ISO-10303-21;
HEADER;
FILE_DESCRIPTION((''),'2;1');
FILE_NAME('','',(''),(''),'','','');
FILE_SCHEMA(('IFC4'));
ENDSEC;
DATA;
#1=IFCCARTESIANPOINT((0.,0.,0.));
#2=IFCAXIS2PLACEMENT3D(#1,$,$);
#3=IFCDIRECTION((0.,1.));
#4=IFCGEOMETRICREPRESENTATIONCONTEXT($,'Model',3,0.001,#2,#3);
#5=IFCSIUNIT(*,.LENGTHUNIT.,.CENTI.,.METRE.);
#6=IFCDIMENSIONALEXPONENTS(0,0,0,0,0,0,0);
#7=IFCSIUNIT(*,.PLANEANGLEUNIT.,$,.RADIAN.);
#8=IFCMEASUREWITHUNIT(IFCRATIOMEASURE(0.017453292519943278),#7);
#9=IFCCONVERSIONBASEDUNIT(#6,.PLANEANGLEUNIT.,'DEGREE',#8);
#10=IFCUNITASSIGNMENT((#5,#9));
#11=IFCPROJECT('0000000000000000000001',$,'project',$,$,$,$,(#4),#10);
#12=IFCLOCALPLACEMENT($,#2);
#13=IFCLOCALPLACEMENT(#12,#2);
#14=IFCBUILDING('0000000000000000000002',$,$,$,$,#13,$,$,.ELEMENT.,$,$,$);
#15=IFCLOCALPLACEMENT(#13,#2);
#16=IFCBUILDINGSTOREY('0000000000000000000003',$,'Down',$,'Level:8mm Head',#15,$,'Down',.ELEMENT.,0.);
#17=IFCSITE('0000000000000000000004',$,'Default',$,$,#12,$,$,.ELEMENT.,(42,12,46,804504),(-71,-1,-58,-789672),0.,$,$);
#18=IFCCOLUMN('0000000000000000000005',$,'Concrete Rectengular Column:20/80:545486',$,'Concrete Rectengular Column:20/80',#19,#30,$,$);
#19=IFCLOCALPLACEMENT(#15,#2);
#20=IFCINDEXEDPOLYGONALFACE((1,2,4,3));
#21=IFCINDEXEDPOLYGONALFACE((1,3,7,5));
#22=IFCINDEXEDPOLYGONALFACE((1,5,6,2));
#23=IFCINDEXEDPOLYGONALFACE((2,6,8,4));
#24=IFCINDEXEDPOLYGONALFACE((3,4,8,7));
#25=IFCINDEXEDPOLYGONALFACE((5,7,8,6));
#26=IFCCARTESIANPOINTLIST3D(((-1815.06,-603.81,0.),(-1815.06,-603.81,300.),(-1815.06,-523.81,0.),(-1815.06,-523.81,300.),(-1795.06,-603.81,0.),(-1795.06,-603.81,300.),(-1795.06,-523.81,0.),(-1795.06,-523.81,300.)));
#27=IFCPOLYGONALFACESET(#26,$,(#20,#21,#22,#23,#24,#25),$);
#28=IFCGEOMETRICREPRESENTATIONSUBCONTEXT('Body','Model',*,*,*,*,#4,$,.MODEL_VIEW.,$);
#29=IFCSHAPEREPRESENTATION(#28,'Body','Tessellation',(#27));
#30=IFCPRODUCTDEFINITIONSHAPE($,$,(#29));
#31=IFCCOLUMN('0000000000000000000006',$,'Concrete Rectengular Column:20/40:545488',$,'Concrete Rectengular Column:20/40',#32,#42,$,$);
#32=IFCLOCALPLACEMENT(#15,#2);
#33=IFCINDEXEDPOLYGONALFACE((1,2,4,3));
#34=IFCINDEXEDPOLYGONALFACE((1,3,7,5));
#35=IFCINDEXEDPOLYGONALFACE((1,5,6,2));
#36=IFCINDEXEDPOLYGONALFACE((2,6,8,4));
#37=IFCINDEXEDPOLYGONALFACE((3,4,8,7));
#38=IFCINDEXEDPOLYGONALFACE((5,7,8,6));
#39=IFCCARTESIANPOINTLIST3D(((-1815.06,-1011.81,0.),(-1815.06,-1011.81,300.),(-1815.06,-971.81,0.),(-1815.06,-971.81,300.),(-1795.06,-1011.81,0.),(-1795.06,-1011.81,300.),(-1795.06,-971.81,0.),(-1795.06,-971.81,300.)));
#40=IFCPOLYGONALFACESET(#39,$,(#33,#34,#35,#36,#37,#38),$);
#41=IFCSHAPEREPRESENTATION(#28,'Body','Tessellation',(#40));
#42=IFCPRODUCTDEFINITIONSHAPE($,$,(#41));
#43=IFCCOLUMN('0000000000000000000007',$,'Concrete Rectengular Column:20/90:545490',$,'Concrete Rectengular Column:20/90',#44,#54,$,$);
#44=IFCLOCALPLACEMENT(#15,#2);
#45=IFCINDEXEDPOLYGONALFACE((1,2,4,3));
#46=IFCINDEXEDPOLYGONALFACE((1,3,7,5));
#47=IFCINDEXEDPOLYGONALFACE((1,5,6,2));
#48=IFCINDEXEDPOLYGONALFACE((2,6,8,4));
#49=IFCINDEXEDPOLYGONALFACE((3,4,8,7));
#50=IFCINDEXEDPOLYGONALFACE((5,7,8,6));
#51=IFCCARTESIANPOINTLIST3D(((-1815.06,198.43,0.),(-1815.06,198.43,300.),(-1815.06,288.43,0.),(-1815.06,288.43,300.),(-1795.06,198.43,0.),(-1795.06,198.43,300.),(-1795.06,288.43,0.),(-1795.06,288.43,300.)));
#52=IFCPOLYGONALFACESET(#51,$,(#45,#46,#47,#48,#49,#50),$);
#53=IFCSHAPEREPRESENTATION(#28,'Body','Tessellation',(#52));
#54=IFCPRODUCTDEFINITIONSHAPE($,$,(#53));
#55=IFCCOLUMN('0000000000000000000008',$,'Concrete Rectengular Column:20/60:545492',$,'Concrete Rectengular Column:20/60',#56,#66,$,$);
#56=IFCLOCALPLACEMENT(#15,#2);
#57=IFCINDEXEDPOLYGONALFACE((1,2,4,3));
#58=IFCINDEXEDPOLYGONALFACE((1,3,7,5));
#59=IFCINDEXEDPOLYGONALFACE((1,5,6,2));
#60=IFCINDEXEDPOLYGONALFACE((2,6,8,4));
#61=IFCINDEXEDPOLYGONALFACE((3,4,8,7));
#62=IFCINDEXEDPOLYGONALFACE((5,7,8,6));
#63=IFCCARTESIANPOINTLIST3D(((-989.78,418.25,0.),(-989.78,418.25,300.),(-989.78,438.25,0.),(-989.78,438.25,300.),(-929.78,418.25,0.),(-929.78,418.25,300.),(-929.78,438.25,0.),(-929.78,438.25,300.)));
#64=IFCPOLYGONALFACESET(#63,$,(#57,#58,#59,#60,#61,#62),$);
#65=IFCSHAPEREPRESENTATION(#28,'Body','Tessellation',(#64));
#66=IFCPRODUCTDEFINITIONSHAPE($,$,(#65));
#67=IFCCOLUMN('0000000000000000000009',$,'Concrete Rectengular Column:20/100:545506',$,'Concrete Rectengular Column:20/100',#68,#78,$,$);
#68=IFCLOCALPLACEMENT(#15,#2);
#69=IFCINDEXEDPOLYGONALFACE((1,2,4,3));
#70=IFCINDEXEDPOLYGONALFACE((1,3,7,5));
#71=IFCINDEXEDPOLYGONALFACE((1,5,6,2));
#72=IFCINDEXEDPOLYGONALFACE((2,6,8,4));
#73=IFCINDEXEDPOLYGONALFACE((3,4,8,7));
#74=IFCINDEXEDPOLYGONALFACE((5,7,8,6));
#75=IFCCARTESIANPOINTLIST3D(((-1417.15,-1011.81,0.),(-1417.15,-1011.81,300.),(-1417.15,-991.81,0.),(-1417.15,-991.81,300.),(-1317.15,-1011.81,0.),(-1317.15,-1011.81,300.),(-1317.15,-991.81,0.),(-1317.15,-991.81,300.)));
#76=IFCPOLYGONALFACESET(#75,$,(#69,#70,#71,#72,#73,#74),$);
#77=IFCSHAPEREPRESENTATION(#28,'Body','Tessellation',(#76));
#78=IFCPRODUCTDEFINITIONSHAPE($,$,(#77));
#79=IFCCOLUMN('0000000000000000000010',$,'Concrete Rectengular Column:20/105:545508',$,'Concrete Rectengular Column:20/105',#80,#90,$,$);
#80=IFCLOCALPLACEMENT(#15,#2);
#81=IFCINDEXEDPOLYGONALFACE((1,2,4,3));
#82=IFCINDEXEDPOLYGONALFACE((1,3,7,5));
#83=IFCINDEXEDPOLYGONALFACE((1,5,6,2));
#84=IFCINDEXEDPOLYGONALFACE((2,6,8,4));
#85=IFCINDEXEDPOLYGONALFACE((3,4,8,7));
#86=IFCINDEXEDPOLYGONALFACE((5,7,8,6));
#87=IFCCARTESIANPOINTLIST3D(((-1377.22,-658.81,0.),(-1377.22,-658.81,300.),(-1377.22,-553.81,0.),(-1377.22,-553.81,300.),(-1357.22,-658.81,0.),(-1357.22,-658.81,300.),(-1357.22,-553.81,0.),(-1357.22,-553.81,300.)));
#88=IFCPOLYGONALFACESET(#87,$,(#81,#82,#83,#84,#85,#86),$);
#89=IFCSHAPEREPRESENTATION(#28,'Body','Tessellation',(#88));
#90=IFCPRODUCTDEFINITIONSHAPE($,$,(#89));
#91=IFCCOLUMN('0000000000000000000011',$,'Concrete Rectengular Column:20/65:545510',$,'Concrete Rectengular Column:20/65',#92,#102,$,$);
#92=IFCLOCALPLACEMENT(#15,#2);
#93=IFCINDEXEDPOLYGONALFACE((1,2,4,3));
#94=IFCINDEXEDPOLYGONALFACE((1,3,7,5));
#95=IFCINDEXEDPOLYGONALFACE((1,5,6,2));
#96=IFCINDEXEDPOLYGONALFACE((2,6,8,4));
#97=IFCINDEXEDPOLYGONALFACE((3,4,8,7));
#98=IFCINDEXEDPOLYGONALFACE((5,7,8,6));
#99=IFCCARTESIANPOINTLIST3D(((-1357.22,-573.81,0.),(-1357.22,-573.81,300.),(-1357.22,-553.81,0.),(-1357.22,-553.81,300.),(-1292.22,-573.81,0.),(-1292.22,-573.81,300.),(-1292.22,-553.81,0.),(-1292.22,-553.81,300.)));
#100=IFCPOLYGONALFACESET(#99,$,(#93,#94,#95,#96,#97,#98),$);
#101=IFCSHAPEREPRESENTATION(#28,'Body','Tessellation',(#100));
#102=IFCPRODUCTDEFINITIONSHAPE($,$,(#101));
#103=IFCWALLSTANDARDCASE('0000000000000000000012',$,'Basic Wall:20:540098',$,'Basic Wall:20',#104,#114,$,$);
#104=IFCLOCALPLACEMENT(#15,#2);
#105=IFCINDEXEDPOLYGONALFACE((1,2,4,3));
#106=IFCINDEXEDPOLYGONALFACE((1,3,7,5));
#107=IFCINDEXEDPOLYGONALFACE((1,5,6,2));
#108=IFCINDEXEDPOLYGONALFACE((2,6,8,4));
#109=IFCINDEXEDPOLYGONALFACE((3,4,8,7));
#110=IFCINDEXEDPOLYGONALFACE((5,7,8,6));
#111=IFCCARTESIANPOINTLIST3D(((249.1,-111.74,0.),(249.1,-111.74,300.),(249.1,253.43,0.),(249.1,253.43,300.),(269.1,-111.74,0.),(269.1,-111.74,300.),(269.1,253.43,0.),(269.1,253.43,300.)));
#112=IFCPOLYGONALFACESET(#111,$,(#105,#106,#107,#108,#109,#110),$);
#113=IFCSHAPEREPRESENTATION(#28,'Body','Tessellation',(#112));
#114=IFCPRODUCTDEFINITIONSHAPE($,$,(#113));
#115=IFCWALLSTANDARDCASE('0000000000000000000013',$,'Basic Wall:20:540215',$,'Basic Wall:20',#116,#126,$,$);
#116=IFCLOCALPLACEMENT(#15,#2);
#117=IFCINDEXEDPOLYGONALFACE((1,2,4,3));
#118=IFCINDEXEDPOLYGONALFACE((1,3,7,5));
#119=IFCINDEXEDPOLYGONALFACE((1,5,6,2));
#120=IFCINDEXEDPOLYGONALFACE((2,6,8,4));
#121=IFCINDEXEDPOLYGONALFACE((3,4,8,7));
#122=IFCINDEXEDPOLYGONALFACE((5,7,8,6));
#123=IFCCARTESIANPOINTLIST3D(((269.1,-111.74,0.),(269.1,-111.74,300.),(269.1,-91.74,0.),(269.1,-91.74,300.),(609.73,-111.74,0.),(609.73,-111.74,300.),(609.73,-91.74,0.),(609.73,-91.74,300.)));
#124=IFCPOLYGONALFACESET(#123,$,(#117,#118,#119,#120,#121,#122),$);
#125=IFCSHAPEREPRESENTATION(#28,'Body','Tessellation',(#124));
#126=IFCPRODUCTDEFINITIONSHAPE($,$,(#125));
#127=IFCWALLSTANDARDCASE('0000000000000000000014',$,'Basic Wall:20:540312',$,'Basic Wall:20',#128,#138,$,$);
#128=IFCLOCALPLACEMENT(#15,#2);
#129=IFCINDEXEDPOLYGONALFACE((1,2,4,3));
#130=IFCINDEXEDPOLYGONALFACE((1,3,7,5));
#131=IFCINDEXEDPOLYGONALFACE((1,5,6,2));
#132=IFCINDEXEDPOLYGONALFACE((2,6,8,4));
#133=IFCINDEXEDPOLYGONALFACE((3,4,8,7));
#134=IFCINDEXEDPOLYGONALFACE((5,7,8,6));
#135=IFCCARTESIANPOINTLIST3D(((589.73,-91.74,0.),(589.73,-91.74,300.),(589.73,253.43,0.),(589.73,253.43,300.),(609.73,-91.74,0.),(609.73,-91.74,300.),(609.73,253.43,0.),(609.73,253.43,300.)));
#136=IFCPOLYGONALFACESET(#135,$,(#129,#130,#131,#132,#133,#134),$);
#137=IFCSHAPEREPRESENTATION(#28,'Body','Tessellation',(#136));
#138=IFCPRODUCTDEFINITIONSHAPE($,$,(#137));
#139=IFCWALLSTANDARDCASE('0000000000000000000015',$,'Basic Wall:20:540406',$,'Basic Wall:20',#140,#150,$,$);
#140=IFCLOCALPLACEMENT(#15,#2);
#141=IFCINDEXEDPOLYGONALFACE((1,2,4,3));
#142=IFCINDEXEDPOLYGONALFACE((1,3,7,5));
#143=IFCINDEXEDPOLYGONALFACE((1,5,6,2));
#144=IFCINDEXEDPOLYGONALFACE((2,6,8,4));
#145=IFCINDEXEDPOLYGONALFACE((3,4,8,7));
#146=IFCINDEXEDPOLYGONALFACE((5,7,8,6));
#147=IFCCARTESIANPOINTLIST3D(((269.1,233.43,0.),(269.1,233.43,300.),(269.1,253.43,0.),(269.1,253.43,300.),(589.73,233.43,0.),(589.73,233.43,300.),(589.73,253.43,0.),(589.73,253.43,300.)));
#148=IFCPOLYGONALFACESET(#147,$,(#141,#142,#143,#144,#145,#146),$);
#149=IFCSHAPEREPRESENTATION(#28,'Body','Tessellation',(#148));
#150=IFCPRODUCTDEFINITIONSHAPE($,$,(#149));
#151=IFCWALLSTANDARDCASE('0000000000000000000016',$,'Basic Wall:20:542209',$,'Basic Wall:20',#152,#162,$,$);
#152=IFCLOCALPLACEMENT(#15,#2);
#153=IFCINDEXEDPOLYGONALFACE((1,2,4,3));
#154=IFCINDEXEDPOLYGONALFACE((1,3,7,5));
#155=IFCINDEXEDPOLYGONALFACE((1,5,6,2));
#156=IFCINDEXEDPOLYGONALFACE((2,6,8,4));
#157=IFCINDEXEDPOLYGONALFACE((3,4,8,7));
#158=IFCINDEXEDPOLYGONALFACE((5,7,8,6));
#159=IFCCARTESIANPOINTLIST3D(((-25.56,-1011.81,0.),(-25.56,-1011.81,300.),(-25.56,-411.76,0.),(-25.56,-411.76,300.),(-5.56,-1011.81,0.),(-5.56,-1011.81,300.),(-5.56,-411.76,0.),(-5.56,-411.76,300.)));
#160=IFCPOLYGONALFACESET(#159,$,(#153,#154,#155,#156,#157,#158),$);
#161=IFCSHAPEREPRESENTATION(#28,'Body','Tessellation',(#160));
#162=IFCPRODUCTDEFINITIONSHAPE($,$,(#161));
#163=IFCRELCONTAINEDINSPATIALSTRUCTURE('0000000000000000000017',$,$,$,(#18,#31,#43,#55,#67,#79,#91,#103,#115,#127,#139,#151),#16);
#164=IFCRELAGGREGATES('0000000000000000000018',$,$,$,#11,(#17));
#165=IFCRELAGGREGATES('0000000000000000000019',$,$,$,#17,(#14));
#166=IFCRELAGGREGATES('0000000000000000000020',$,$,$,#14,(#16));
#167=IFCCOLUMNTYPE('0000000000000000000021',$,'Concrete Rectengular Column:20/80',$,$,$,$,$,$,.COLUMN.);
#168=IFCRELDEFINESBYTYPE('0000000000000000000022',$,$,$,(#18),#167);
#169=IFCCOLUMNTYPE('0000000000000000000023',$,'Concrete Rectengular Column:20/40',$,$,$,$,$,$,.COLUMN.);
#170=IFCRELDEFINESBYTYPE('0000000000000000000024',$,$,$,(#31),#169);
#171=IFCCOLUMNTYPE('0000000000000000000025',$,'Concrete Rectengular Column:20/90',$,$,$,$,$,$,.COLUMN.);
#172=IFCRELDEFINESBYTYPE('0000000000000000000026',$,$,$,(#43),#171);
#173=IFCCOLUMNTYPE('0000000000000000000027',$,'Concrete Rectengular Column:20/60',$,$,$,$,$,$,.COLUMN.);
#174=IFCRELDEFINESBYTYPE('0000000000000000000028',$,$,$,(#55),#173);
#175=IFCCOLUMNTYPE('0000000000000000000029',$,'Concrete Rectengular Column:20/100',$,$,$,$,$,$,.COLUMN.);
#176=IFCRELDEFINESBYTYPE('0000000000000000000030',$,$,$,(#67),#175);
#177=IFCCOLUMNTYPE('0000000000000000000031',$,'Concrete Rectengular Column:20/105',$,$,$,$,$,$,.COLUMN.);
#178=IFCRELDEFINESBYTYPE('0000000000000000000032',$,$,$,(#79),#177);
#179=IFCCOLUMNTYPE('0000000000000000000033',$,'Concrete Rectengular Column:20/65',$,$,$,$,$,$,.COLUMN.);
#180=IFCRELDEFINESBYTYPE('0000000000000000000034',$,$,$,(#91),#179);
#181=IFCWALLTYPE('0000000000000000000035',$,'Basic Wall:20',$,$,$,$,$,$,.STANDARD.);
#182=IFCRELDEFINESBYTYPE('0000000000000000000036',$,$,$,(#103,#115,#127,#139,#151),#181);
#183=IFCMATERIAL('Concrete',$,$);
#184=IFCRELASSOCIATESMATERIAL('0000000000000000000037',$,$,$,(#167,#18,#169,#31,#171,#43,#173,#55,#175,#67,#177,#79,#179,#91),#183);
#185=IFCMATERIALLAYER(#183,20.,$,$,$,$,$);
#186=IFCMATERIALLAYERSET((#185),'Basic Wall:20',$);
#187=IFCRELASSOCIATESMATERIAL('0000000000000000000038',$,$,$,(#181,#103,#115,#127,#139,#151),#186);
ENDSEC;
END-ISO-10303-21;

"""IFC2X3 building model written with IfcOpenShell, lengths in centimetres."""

from ifc_helpers import new_model, entity, si_unit, converted_unit, direction, frame, frame_2d, origin, origin_2d_with_axis, place, context, subcontext, project, spatial, rectangle, extrude, source, transform, mapped, material, layer, layer_set, layer_usage, type_object, type_shapes, element, save


model = new_model("IFC2X3")

# Units and contexts
model_context = context("Model", 3, precision=0.001, world=origin(), true_north=direction((0.0, 1.0)))
body_context = subcontext(model_context, "Body", "Model", "MODEL_VIEW")
ifc_project = project(units=[si_unit("LENGTHUNIT", "METRE", prefix="CENTI"), converted_unit("PLANEANGLEUNIT", "DEGREE", entity("IfcRatioMeasure", 0.017453292519943278), si_unit("PLANEANGLEUNIT", "RADIAN"), dimensions=[0, 0, 0, 0, 0, 0, 0])], contexts=[model_context])

# Site, building, storey
site_placement = place(None, origin())
site = spatial("IfcSite", under=ifc_project, at=site_placement, Name="Default", CompositionType="ELEMENT", RefLatitude=(42, 12, 46, 804504), RefLongitude=(-71, -1, -58, -789672), RefElevation=0.0)
building_placement = place(site_placement, origin())
building = spatial("IfcBuilding", under=site, at=building_placement, CompositionType="ELEMENT")
storey_placement = place(building_placement, origin())
storey = spatial("IfcBuildingStorey", under=building, at=storey_placement, Name="Down", ObjectType="Level:8mm Head", LongName="Down", CompositionType="ELEMENT", Elevation=0.0)

# Columns
ifc_material = material(Name="Concrete")
column_type_1 = type_object("IfcColumnType", Name="Concrete Rectengular Column:20/80", PredefinedType="COLUMN", material=ifc_material)
shared_shape_1 = source(origin(), body_context, "Body", "SweptSolid", [
    extrude(rectangle(XDim=80.0, YDim=20.0, at=frame_2d((0.0, 0.0), x_axis=(1.0, 0.0))), frame((-1805.06, -563.81, 0.0), z_axis=(0.0, 0.0, 1.0), x_axis=(0.0, -1.0, 0.0)), (0.0, 0.0, 1.0), 300.0),
])
type_shapes(column_type_1, [shared_shape_1])
column_1_placement = place(storey_placement, origin())
element("IfcColumn", 1, at=column_1_placement, inside=storey, type_object=column_type_1, material=ifc_material, Name="Concrete Rectengular Column:20/80:545486", ObjectType="Concrete Rectengular Column:20/80", context=body_context, shape_type="MappedRepresentation", body=[
    mapped(shared_shape_1, transform((0.0, 0.0, 0.0), scale=1.0)),
])
column_type_2 = type_object("IfcColumnType", Name="Concrete Rectengular Column:20/40", PredefinedType="COLUMN", material=ifc_material)
shared_shape_2 = source(origin(), body_context, "Body", "SweptSolid", [
    extrude(rectangle(XDim=40.0, YDim=20.0, at=frame_2d((0.0, 0.0), x_axis=(1.0, 0.0))), frame((-1805.06, -991.81, 0.0), z_axis=(0.0, 0.0, 1.0), x_axis=(0.0, -1.0, 0.0)), (0.0, 0.0, 1.0), 300.0),
])
type_shapes(column_type_2, [shared_shape_2])
column_2_placement = place(storey_placement, origin())
element("IfcColumn", 2, at=column_2_placement, inside=storey, type_object=column_type_2, material=ifc_material, Name="Concrete Rectengular Column:20/40:545488", ObjectType="Concrete Rectengular Column:20/40", context=body_context, shape_type="MappedRepresentation", body=[
    mapped(shared_shape_2, transform((0.0, 0.0, 0.0), scale=1.0)),
])
column_type_3 = type_object("IfcColumnType", Name="Concrete Rectengular Column:20/90", PredefinedType="COLUMN", material=ifc_material)
shared_shape_3 = source(origin(), body_context, "Body", "SweptSolid", [
    extrude(rectangle(XDim=90.0, YDim=20.0, at=frame_2d((0.0, 0.0), x_axis=(1.0, 0.0))), frame((-1805.06, 243.43, 0.0), z_axis=(0.0, 0.0, 1.0), x_axis=(0.0, -1.0, 0.0)), (0.0, 0.0, 1.0), 300.0),
])
type_shapes(column_type_3, [shared_shape_3])
column_3_placement = place(storey_placement, origin())
element("IfcColumn", 3, at=column_3_placement, inside=storey, type_object=column_type_3, material=ifc_material, Name="Concrete Rectengular Column:20/90:545490", ObjectType="Concrete Rectengular Column:20/90", context=body_context, shape_type="MappedRepresentation", body=[
    mapped(shared_shape_3, transform((0.0, 0.0, 0.0), scale=1.0)),
])
column_type_4 = type_object("IfcColumnType", Name="Concrete Rectengular Column:20/60", PredefinedType="COLUMN", material=ifc_material)
shared_shape_4 = source(origin(), body_context, "Body", "SweptSolid", [
    extrude(rectangle(XDim=20.0, YDim=60.0, at=frame_2d((0.0, 0.0), x_axis=(1.0, 0.0))), frame((-959.78, 428.25, 0.0), z_axis=(0.0, 0.0, 1.0), x_axis=(0.0, -1.0, 0.0)), (0.0, 0.0, 1.0), 300.0),
])
type_shapes(column_type_4, [shared_shape_4])
column_4_placement = place(storey_placement, origin())
element("IfcColumn", 4, at=column_4_placement, inside=storey, type_object=column_type_4, material=ifc_material, Name="Concrete Rectengular Column:20/60:545492", ObjectType="Concrete Rectengular Column:20/60", context=body_context, shape_type="MappedRepresentation", body=[
    mapped(shared_shape_4, transform((0.0, 0.0, 0.0), scale=1.0)),
])
column_type_5 = type_object("IfcColumnType", Name="Concrete Rectengular Column:20/100", PredefinedType="COLUMN", material=ifc_material)
shared_shape_5 = source(origin(), body_context, "Body", "SweptSolid", [
    extrude(rectangle(XDim=20.0, YDim=100.0, at=frame_2d((0.0, 0.0), x_axis=(1.0, 0.0))), frame((-1367.15, -1001.81, 0.0), z_axis=(0.0, 0.0, 1.0), x_axis=(0.0, -1.0, 0.0)), (0.0, 0.0, 1.0), 300.0),
])
type_shapes(column_type_5, [shared_shape_5])
column_5_placement = place(storey_placement, origin())
element("IfcColumn", 5, at=column_5_placement, inside=storey, type_object=column_type_5, material=ifc_material, Name="Concrete Rectengular Column:20/100:545506", ObjectType="Concrete Rectengular Column:20/100", context=body_context, shape_type="MappedRepresentation", body=[
    mapped(shared_shape_5, transform((0.0, 0.0, 0.0), scale=1.0)),
])
column_type_6 = type_object("IfcColumnType", Name="Concrete Rectengular Column:20/105", PredefinedType="COLUMN", material=ifc_material)
shared_shape_6 = source(origin(), body_context, "Body", "SweptSolid", [
    extrude(rectangle(XDim=105.0, YDim=20.0, at=frame_2d((0.0, 0.0), x_axis=(1.0, 0.0))), frame((-1367.22, -606.31, 0.0), z_axis=(0.0, 0.0, 1.0), x_axis=(0.0, -1.0, 0.0)), (0.0, 0.0, 1.0), 300.0),
])
type_shapes(column_type_6, [shared_shape_6])
column_6_placement = place(storey_placement, origin())
element("IfcColumn", 6, at=column_6_placement, inside=storey, type_object=column_type_6, material=ifc_material, Name="Concrete Rectengular Column:20/105:545508", ObjectType="Concrete Rectengular Column:20/105", context=body_context, shape_type="MappedRepresentation", body=[
    mapped(shared_shape_6, transform((0.0, 0.0, 0.0), scale=1.0)),
])
column_type_7 = type_object("IfcColumnType", Name="Concrete Rectengular Column:20/65", PredefinedType="COLUMN", material=ifc_material)
shared_shape_7 = source(origin(), body_context, "Body", "SweptSolid", [
    extrude(rectangle(XDim=20.0, YDim=65.0, at=origin_2d_with_axis()), frame((-1324.72, -563.81, 0.0), z_axis=(0.0, 0.0, 1.0), x_axis=(0.0, -1.0, 0.0)), (0.0, 0.0, 1.0), 300.0),
])
type_shapes(column_type_7, [shared_shape_7])
column_7_placement = place(storey_placement, origin())
element("IfcColumn", 7, at=column_7_placement, inside=storey, type_object=column_type_7, material=ifc_material, Name="Concrete Rectengular Column:20/65:545510", ObjectType="Concrete Rectengular Column:20/65", context=body_context, shape_type="MappedRepresentation", body=[
    mapped(shared_shape_7, transform((0.0, 0.0, 0.0), scale=1.0)),
])

# Walls
ifc_layer = layer(ifc_material, 20.0)
ifc_layer_set = layer_set([ifc_layer], Name="Basic Wall:20")
ifc_layer_usage_1 = layer_usage(ifc_layer_set, "AXIS2", "POSITIVE", -10.0)
wall_type = type_object("IfcWallType", Name="Basic Wall:20", PredefinedType="STANDARD", material=ifc_layer_set)
wall_1_placement = place(storey_placement, frame((259.1, 253.43, 0.0), z_axis=(0.0, 0.0, 1.0), x_axis=(0.0, -1.0, 0.0)))
element("IfcWallStandardCase", 8, at=wall_1_placement, inside=storey, type_object=wall_type, material=ifc_layer_usage_1, Name="Basic Wall:20:540098", ObjectType="Basic Wall:20", context=body_context, shape_type="SweptSolid", body=[
    extrude(rectangle(XDim=365.17, YDim=20.0, at=frame_2d((182.58, 0.0), x_axis=(-1.0, 0.0))), origin(), (0.0, 0.0, 1.0), 300.0),
])
ifc_layer_usage_2 = layer_usage(ifc_layer_set, "AXIS2", "POSITIVE", -10.0)
wall_2_placement = place(storey_placement, frame((269.1, -101.74, 0.0)))
element("IfcWallStandardCase", 9, at=wall_2_placement, inside=storey, type_object=wall_type, material=ifc_layer_usage_2, Name="Basic Wall:20:540215", ObjectType="Basic Wall:20", context=body_context, shape_type="SweptSolid", body=[
    extrude(rectangle(XDim=340.63, YDim=20.0, at=frame_2d((170.31, 0.0), x_axis=(-1.0, 0.0))), origin(), (0.0, 0.0, 1.0), 300.0),
])
ifc_layer_usage_3 = layer_usage(ifc_layer_set, "AXIS2", "POSITIVE", -10.0)
wall_3_placement = place(storey_placement, frame((599.73, -91.74, 0.0), z_axis=(0.0, 0.0, 1.0), x_axis=(0.0, 1.0, 0.0)))
element("IfcWallStandardCase", 10, at=wall_3_placement, inside=storey, type_object=wall_type, material=ifc_layer_usage_3, Name="Basic Wall:20:540312", ObjectType="Basic Wall:20", context=body_context, shape_type="SweptSolid", body=[
    extrude(rectangle(XDim=345.17, YDim=20.0, at=frame_2d((172.58, 0.0), x_axis=(-1.0, 0.0))), origin(), (0.0, 0.0, 1.0), 300.0),
])
ifc_layer_usage_4 = layer_usage(ifc_layer_set, "AXIS2", "POSITIVE", -10.0)
wall_4_placement = place(storey_placement, frame((589.73, 243.43, 0.0), z_axis=(0.0, 0.0, 1.0), x_axis=(-1.0, 0.0, 0.0)))
element("IfcWallStandardCase", 11, at=wall_4_placement, inside=storey, type_object=wall_type, material=ifc_layer_usage_4, Name="Basic Wall:20:540406", ObjectType="Basic Wall:20", context=body_context, shape_type="SweptSolid", body=[
    extrude(rectangle(XDim=320.63, YDim=20.0, at=frame_2d((160.31, 0.0), x_axis=(-1.0, 0.0))), origin(), (0.0, 0.0, 1.0), 300.0),
])
ifc_layer_usage_5 = layer_usage(ifc_layer_set, "AXIS2", "NEGATIVE", 10.0)
wall_5_placement = place(storey_placement, frame((-15.56, -411.76, 0.0), z_axis=(0.0, 0.0, 1.0), x_axis=(0.0, -1.0, 0.0)))
element("IfcWallStandardCase", 12, at=wall_5_placement, inside=storey, type_object=wall_type, material=ifc_layer_usage_5, Name="Basic Wall:20:542209", ObjectType="Basic Wall:20", context=body_context, shape_type="SweptSolid", body=[
    extrude(rectangle(XDim=600.05, YDim=20.0, at=frame_2d((300.02, 0.0), x_axis=(-1.0, 0.0))), origin(), (0.0, 0.0, 1.0), 300.0),
])

save(model, "model.ifc")
